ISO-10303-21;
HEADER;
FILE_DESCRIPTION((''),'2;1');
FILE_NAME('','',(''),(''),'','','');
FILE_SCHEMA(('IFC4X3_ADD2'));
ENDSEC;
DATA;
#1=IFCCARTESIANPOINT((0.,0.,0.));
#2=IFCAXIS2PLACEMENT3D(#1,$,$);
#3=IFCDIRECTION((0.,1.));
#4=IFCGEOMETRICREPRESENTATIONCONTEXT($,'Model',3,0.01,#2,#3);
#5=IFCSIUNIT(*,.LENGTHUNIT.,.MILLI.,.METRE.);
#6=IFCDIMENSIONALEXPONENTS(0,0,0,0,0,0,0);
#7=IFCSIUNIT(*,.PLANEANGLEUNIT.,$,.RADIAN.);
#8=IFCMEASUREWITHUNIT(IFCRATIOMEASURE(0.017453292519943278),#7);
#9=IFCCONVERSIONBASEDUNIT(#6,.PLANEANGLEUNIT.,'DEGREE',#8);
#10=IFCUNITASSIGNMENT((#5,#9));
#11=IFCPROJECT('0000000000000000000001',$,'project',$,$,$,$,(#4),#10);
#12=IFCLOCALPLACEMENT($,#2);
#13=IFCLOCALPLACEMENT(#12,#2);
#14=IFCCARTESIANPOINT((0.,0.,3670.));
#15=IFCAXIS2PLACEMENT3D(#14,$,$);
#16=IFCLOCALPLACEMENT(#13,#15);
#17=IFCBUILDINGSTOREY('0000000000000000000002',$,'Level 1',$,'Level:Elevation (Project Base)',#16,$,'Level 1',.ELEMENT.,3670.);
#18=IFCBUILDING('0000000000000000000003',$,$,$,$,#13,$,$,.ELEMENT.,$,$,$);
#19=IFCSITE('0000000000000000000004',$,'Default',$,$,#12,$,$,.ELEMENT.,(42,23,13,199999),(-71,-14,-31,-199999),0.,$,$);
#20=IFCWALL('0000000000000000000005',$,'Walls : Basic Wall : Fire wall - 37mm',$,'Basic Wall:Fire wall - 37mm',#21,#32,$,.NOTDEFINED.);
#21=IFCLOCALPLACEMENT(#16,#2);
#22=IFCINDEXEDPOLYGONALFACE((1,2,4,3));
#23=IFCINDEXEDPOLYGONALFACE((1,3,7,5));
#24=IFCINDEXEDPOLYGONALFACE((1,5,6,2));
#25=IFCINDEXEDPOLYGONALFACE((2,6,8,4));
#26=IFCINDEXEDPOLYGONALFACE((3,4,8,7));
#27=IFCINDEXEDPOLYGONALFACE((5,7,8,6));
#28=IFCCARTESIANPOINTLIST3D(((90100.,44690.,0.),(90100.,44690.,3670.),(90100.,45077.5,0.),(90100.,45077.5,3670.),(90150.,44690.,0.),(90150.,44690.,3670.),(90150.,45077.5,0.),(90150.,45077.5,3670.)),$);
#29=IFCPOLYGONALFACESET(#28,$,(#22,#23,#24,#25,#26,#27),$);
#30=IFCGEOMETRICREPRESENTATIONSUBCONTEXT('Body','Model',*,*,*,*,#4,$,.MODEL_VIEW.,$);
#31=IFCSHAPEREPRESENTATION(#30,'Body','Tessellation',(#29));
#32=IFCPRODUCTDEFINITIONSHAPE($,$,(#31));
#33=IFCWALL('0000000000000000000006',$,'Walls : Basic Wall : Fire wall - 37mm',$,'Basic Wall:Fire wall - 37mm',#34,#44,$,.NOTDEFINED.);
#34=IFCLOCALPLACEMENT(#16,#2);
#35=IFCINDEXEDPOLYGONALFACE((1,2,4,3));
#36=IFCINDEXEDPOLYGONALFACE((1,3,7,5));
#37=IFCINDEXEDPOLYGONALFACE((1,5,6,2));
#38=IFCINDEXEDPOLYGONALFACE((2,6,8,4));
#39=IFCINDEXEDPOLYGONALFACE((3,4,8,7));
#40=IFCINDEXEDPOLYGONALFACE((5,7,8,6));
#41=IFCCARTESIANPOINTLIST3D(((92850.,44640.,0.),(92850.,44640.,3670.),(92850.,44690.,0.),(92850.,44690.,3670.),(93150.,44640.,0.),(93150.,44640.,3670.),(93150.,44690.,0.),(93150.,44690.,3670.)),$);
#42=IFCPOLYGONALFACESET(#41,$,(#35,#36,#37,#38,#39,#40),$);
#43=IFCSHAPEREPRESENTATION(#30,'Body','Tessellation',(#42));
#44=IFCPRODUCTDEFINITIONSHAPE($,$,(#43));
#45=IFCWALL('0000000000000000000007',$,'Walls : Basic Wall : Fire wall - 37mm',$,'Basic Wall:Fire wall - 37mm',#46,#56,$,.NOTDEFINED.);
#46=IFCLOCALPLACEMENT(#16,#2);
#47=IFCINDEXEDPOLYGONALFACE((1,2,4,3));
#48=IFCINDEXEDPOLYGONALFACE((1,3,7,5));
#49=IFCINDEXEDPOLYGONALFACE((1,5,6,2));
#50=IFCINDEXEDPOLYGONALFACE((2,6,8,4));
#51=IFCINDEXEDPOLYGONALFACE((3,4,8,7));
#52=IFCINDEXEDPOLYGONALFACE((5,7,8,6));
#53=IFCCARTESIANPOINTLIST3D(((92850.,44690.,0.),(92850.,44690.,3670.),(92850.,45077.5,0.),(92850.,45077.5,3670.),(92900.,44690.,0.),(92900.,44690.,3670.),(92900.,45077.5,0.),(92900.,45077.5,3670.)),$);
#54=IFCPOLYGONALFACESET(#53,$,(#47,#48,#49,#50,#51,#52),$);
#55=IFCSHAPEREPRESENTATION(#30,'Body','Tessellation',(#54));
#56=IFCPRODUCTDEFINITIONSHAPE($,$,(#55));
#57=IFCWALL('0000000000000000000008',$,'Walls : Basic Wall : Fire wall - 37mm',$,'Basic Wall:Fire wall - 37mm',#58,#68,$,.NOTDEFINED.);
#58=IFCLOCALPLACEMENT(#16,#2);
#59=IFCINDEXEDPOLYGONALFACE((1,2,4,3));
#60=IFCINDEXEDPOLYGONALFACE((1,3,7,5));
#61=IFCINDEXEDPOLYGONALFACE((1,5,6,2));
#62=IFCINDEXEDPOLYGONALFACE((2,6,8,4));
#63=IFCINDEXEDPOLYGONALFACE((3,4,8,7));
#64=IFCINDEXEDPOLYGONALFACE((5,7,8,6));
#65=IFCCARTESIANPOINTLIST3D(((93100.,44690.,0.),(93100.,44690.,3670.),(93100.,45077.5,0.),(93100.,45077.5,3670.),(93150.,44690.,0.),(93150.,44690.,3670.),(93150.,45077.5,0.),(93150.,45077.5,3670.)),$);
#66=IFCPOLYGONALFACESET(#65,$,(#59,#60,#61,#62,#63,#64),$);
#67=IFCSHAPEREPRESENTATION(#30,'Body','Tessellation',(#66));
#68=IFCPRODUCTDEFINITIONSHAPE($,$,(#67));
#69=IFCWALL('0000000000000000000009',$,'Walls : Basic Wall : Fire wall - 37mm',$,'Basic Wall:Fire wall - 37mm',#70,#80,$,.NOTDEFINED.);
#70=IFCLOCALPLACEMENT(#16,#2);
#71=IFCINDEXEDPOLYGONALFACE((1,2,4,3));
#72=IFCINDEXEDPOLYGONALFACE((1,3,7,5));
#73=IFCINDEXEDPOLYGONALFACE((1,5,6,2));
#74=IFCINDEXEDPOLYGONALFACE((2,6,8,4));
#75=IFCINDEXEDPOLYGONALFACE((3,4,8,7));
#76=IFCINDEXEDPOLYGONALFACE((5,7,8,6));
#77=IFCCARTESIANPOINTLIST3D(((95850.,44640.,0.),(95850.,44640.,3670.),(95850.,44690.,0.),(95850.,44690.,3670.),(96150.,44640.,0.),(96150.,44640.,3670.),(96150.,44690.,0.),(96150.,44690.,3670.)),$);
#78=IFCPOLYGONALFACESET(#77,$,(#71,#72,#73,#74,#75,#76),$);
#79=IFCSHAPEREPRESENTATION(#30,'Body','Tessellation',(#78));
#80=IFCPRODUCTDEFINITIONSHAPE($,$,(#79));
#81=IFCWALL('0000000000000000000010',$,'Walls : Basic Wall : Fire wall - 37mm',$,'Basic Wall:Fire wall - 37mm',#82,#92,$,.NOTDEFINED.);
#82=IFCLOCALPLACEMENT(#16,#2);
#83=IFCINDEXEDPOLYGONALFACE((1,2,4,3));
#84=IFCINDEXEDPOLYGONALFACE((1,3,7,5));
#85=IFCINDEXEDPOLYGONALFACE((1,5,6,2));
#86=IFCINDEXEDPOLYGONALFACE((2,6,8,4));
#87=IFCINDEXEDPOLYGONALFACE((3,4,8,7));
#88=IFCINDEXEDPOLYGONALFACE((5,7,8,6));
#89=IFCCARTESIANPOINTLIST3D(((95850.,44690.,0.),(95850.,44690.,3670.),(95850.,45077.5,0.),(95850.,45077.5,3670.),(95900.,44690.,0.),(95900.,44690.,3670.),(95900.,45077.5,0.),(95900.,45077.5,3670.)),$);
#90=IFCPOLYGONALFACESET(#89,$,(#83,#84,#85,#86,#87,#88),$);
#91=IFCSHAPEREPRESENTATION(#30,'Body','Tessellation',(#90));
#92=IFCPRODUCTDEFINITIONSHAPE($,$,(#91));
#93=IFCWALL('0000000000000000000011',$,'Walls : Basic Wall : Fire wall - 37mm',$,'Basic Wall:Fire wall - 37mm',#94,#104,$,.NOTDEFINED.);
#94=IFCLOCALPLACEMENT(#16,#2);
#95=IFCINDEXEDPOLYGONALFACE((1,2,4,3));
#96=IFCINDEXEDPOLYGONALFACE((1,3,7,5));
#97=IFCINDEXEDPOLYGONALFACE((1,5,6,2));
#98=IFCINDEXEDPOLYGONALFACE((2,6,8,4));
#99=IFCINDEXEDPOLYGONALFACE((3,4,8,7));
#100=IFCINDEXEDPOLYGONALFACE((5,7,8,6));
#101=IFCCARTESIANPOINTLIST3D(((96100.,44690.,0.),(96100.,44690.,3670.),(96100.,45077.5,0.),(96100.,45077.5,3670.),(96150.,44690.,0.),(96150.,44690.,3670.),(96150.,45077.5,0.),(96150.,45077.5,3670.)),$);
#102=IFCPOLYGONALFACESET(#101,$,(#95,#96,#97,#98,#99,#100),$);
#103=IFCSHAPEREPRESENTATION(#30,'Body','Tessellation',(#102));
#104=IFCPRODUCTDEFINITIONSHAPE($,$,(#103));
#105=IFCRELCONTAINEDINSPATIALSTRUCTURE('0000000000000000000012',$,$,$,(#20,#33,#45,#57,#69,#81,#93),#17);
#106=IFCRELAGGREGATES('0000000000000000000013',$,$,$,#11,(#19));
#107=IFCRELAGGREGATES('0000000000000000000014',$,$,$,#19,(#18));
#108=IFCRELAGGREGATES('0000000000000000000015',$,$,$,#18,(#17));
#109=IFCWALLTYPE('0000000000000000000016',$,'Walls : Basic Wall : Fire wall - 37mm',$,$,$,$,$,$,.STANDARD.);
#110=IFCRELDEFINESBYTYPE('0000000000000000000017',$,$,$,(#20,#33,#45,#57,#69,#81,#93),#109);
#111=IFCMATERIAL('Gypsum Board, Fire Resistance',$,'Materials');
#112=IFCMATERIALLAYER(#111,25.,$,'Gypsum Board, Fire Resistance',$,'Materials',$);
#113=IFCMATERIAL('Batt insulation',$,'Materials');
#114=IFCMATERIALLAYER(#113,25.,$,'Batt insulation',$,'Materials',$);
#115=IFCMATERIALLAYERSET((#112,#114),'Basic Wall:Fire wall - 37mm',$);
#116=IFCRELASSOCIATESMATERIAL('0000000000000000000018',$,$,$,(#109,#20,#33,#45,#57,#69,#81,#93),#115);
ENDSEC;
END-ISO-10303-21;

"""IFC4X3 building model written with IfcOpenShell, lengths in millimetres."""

from ifc_helpers import new_model, entity, si_unit, converted_unit, direction, frame, frame_2d, origin, place, context, subcontext, project, spatial, rectangle, extrude, material, layer, layer_set, type_object, element, save


model = new_model("IFC4X3")

# Units and contexts
model_context = context("Model", 3, precision=0.01, world=origin(), true_north=direction((0.0, 1.0)))
body_context = subcontext(model_context, "Body", "Model", "MODEL_VIEW")
ifc_project = project(units=[si_unit("LENGTHUNIT", "METRE", prefix="MILLI"), converted_unit("PLANEANGLEUNIT", "DEGREE", entity("IfcRatioMeasure", 0.017453292519943278), si_unit("PLANEANGLEUNIT", "RADIAN"), dimensions=[0, 0, 0, 0, 0, 0, 0])], contexts=[model_context])

# Site, building, storey
site_placement = place(None, origin())
site = spatial("IfcSite", under=ifc_project, at=site_placement, Name="Default", CompositionType="ELEMENT", RefLatitude=(42, 23, 13, 199999), RefLongitude=(-71, -14, -31, -199999), RefElevation=0.0)
building_placement = place(site_placement, origin())
building = spatial("IfcBuilding", under=site, at=building_placement, CompositionType="ELEMENT")
storey_placement = place(building_placement, frame((0.0, 0.0, 3670.0)))
storey = spatial("IfcBuildingStorey", under=building, at=storey_placement, Name="Level 1", ObjectType="Level:Elevation (Project Base)", LongName="Level 1", CompositionType="ELEMENT", Elevation=3670.0)

# Walls
ifc_material_1 = material(Name="Gypsum Board, Fire Resistance", Category="Materials")
ifc_layer_1 = layer(ifc_material_1, 25.0, Name="Gypsum Board, Fire Resistance", Category="Materials")
ifc_material_2 = material(Name="Batt insulation", Category="Materials")
ifc_layer_2 = layer(ifc_material_2, 25.0, Name="Batt insulation", Category="Materials")
ifc_layer_set = layer_set([ifc_layer_1, ifc_layer_2], Name="Basic Wall:Fire wall - 37mm")
wall_type = type_object("IfcWallType", Name="Walls : Basic Wall : Fire wall - 37mm", PredefinedType="STANDARD", material=ifc_layer_set)
for number, where, z_axis, x_axis, name in (
    (1, (90125.0, 45077.5, 0.0), (0.0, 0.0, 1.0), (0.0, -1.0, 0.0), "Walls : Basic Wall : Fire wall - 37mm"),
):
    element("IfcWall", number, at=place(storey_placement, frame(where, z_axis=z_axis, x_axis=x_axis)), inside=storey, type_object=wall_type, material=ifc_layer_set, Name=name, ObjectType="Basic Wall:Fire wall - 37mm", PredefinedType="NOTDEFINED", context=body_context, shape_type="SweptSolid", body=[
        extrude(rectangle(XDim=387.5, YDim=50.0, at=frame_2d((193.7, 0.0), x_axis=(-1.0, 0.0))), origin(), (0.0, 0.0, 1.0), 3670.0),
    ])
wall_1_placement = place(storey_placement, frame((92850.0, 44665.0, 0.0)))
element("IfcWall", 2, at=wall_1_placement, inside=storey, type_object=wall_type, material=ifc_layer_set, Name="Walls : Basic Wall : Fire wall - 37mm", ObjectType="Basic Wall:Fire wall - 37mm", PredefinedType="NOTDEFINED", context=body_context, shape_type="SweptSolid", body=[
    extrude(rectangle(XDim=300.0, YDim=50.0, at=frame_2d((150.0, 0.0), x_axis=(-1.0, 0.0))), origin(), (0.0, 0.0, 1.0), 3670.0),
])
for number, where, z_axis, x_axis, name in (
    (3, (92875.0, 45077.5, 0.0), (0.0, 0.0, 1.0), (0.0, -1.0, 0.0), "Walls : Basic Wall : Fire wall - 37mm"),
    (4, (93125.0, 45077.5, 0.0), (0.0, 0.0, 1.0), (0.0, -1.0, 0.0), "Walls : Basic Wall : Fire wall - 37mm"),
):
    element("IfcWall", number, at=place(storey_placement, frame(where, z_axis=z_axis, x_axis=x_axis)), inside=storey, type_object=wall_type, material=ifc_layer_set, Name=name, ObjectType="Basic Wall:Fire wall - 37mm", PredefinedType="NOTDEFINED", context=body_context, shape_type="SweptSolid", body=[
        extrude(rectangle(XDim=387.5, YDim=50.0, at=frame_2d((193.7, 0.0), x_axis=(-1.0, 0.0))), origin(), (0.0, 0.0, 1.0), 3670.0),
    ])
wall_2_placement = place(storey_placement, frame((95850.0, 44665.0, 0.0)))
element("IfcWall", 5, at=wall_2_placement, inside=storey, type_object=wall_type, material=ifc_layer_set, Name="Walls : Basic Wall : Fire wall - 37mm", ObjectType="Basic Wall:Fire wall - 37mm", PredefinedType="NOTDEFINED", context=body_context, shape_type="SweptSolid", body=[
    extrude(rectangle(XDim=300.0, YDim=50.0, at=frame_2d((150.0, 0.0), x_axis=(-1.0, 0.0))), origin(), (0.0, 0.0, 1.0), 3670.0),
])
for number, where, z_axis, x_axis, name in (
    (6, (95875.0, 45077.5, 0.0), (0.0, 0.0, 1.0), (0.0, -1.0, 0.0), "Walls : Basic Wall : Fire wall - 37mm"),
    (7, (96125.0, 45077.5, 0.0), (0.0, 0.0, 1.0), (0.0, -1.0, 0.0), "Walls : Basic Wall : Fire wall - 37mm"),
):
    element("IfcWall", number, at=place(storey_placement, frame(where, z_axis=z_axis, x_axis=x_axis)), inside=storey, type_object=wall_type, material=ifc_layer_set, Name=name, ObjectType="Basic Wall:Fire wall - 37mm", PredefinedType="NOTDEFINED", context=body_context, shape_type="SweptSolid", body=[
        extrude(rectangle(XDim=387.5, YDim=50.0, at=frame_2d((193.7, 0.0), x_axis=(-1.0, 0.0))), origin(), (0.0, 0.0, 1.0), 3670.0),
    ])

save(model, "model.ifc")
